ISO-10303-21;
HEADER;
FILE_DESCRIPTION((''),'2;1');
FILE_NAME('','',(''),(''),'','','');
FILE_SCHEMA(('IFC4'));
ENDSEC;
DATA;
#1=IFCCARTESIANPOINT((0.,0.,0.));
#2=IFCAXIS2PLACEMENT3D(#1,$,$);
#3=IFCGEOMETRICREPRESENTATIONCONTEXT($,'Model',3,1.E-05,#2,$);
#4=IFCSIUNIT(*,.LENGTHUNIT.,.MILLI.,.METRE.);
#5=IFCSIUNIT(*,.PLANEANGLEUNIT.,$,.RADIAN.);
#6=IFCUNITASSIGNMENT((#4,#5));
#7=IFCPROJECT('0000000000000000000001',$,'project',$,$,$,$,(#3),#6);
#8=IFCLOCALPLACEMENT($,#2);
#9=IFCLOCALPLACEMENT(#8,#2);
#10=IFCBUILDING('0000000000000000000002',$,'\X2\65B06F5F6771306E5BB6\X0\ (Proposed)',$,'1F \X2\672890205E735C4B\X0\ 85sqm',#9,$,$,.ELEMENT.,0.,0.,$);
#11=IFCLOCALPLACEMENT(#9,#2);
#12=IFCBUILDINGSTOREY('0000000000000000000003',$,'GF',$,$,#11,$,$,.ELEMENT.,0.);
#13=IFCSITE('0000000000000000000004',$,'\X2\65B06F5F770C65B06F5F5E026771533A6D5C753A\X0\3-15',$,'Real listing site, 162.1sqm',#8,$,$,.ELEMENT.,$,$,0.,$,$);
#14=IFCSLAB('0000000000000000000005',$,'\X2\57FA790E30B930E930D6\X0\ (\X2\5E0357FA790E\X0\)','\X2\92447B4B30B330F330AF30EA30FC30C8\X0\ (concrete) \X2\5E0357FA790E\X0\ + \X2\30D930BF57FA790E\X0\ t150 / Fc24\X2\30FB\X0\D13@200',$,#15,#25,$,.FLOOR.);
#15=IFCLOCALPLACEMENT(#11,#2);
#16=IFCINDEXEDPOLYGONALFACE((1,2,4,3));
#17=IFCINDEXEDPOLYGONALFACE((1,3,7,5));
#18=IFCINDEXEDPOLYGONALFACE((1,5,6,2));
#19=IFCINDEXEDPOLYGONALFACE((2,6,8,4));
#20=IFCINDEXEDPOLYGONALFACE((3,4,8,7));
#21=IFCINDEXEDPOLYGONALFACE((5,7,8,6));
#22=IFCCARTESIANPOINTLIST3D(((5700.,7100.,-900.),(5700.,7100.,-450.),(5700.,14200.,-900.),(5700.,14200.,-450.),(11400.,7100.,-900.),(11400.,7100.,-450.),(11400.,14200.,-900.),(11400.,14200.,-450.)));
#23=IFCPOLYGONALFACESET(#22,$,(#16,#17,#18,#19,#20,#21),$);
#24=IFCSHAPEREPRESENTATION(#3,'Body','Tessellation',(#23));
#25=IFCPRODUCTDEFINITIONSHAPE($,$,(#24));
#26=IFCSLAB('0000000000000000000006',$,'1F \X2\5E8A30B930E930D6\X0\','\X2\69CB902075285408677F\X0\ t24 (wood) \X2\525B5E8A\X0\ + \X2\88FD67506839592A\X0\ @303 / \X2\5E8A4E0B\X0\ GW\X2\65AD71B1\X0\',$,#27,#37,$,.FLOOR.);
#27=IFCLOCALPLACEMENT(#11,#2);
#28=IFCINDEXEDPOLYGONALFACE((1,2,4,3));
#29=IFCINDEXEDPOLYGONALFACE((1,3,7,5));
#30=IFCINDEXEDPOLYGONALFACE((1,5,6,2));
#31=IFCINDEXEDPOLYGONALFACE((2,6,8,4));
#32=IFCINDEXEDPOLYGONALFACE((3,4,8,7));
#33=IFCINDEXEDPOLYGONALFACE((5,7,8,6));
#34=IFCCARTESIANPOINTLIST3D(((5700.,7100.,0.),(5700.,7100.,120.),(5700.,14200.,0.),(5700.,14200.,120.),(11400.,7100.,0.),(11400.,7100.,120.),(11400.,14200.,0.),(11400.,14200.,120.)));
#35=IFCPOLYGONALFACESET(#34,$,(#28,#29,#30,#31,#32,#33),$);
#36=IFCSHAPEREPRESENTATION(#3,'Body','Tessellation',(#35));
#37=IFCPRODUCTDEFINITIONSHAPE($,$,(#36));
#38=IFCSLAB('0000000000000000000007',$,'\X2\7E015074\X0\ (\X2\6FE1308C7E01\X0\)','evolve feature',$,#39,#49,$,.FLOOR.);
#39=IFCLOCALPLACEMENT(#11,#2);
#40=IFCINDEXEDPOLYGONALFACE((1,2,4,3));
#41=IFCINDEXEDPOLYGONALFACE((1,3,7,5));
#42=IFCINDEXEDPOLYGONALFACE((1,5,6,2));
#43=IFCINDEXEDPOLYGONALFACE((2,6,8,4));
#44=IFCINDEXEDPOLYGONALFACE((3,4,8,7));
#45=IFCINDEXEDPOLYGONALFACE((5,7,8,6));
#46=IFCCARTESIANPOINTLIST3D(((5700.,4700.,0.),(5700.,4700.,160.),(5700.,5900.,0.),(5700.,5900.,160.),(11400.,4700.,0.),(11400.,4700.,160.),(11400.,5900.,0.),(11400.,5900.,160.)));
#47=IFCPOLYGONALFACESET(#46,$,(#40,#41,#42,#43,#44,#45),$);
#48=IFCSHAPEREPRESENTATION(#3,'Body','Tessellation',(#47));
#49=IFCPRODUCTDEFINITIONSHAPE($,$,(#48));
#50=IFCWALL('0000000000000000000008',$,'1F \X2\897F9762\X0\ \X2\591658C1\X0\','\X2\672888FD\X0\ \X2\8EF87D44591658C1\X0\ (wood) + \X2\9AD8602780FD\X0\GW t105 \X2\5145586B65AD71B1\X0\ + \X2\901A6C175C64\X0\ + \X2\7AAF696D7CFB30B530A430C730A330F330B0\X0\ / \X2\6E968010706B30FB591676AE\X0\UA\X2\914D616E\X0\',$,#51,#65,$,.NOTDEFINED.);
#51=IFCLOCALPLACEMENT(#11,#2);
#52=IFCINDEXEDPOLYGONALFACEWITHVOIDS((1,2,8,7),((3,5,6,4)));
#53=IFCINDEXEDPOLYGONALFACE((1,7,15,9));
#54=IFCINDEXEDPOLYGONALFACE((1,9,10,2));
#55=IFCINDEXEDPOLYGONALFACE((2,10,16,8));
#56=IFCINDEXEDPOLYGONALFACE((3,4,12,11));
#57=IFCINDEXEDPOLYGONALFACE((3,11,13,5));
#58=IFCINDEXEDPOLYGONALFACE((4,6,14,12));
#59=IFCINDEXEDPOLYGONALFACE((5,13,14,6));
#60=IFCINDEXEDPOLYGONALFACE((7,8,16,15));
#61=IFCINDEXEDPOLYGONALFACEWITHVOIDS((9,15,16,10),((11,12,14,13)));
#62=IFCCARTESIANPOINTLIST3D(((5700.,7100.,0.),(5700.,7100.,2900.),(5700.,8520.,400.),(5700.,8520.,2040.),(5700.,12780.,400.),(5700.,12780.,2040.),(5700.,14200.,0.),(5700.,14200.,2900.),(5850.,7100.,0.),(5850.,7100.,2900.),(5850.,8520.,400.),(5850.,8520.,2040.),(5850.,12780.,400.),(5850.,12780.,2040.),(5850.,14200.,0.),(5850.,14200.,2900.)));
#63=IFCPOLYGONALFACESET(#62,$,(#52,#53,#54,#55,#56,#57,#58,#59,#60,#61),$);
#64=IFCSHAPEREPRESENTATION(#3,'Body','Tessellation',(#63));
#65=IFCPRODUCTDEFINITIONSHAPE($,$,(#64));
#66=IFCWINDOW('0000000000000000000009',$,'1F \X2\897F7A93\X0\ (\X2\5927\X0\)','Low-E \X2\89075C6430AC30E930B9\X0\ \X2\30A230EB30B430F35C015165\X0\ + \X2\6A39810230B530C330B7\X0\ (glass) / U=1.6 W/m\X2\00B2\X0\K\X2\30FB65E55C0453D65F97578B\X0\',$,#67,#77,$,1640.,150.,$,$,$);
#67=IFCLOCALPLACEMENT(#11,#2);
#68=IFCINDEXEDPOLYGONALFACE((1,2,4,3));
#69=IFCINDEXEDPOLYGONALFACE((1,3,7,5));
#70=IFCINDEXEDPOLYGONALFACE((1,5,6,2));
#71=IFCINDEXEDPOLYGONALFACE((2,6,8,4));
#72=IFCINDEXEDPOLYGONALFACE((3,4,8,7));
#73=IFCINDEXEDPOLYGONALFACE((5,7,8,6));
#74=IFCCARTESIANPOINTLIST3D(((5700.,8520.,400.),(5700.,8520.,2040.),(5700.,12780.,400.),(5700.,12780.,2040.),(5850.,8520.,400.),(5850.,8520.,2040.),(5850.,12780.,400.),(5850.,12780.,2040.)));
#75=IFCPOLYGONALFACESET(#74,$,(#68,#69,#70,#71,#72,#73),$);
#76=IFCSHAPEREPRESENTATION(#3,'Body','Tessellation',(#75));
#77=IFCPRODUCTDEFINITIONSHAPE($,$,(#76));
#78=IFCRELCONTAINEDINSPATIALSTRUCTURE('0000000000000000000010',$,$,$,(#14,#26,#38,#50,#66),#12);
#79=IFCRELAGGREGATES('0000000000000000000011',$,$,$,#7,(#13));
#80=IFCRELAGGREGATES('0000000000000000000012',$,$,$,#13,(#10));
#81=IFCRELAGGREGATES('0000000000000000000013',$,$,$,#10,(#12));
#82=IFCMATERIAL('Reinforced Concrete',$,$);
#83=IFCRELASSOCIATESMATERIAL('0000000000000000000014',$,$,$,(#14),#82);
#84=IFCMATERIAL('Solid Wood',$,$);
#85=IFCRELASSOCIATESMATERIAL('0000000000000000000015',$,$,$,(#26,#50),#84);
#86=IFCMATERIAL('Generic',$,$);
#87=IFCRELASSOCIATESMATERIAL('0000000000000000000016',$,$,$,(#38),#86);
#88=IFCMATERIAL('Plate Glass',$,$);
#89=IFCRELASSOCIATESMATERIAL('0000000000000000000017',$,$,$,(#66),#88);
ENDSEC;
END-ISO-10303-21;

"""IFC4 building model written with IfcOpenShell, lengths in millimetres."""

from ifc_helpers import new_model, si_unit, frame, frame_2d, origin, place, context, project, spatial, rectangle, extrude, material, element, fill, save


model = new_model("IFC4")

# Units and contexts
model_context = context("Model", 3, precision=1e-05, world=origin())
ifc_project = project(units=[si_unit("LENGTHUNIT", "METRE", prefix="MILLI"), si_unit("PLANEANGLEUNIT", "RADIAN")], contexts=[model_context])

# Site, building, storey
site_placement = place(None, origin())
site = spatial("IfcSite", under=ifc_project, at=site_placement, Name="新潟県新潟市東区浜町3-15", ObjectType="Real listing site, 162.1sqm", CompositionType="ELEMENT", RefElevation=0.0)
building_placement = place(site_placement, origin())
building = spatial("IfcBuilding", under=site, at=building_placement, Name="新潟東の家 (Proposed)", ObjectType="1F 木造平屋 85sqm", CompositionType="ELEMENT", ElevationOfRefHeight=0.0, ElevationOfTerrain=0.0)
storey_placement = place(building_placement, origin())
storey = spatial("IfcBuildingStorey", under=building, at=storey_placement, Name="GF", CompositionType="ELEMENT", Elevation=0.0)

# Slabs
ifc_material_1 = material(Name="Reinforced Concrete")
slab_1_placement = place(storey_placement, frame((2850.0, 3550.0, -450.0)))
element("IfcSlab", 1, at=slab_1_placement, inside=storey, material=ifc_material_1, Name="基礎スラブ (布基礎)", Description="鉄筋コンクリート (concrete) 布基礎 + ベタ基礎 t150 / Fc24・D13@200", PredefinedType="FLOOR", context=model_context, shape_type="SweptSolid", body=[
    extrude(rectangle(XDim=5700.0, YDim=7100.0, at=frame_2d((2850.0, 3550.0))), frame((2850.0, 3550.0, -450.0)), (0.0, 0.0, 1.0), 450.0),
])
ifc_material_2 = material(Name="Solid Wood")
slab_2_placement = place(storey_placement, frame((2850.0, 3550.0, 0.0)))
element("IfcSlab", 2, at=slab_2_placement, inside=storey, material=ifc_material_2, Name="1F 床スラブ", Description="構造用合板 t24 (wood) 剛床 + 製材根太 @303 / 床下 GW断熱", PredefinedType="FLOOR", context=model_context, shape_type="SweptSolid", body=[
    extrude(rectangle(XDim=5700.0, YDim=7100.0, at=frame_2d((2850.0, 3550.0))), frame((2850.0, 3550.0, 0.0)), (0.0, 0.0, 1.0), 120.0),
])
ifc_material_3 = material(Name="Generic")
slab_3_placement = place(storey_placement, frame((2850.0, 2350.0, 0.0)))
element("IfcSlab", 3, at=slab_3_placement, inside=storey, material=ifc_material_3, Name="縁側 (濡れ縁)", Description="evolve feature", PredefinedType="FLOOR", context=model_context, shape_type="SweptSolid", body=[
    extrude(rectangle(XDim=5700.0, YDim=1200.0, at=frame_2d((2850.0, 600.0))), frame((2850.0, 2350.0, 0.0)), (0.0, 0.0, 1.0), 160.0),
])

# Shared definitions
ifc_material_4 = material(Name="Plate Glass")

# Wall, opening, window
wall_1_placement = place(storey_placement, frame((2850.0, 3550.0, 0.0)))
wall_1 = element("IfcWall", 4, at=wall_1_placement, inside=storey, material=ifc_material_2, Name="1F 西面 外壁", Description="木製 軸組外壁 (wood) + 高性能GW t105 充填断熱 + 通気層 + 窯業系サイディング / 準耐火・外皮UA配慮", PredefinedType="NOTDEFINED", context=model_context, shape_type="SweptSolid", body=[
    extrude(rectangle(XDim=150.0, YDim=7100.0, at=frame_2d((75.0, 3550.0))), frame((2850.0, 3550.0, 0.0)), (0.0, 0.0, 1.0), 2900.0),
])
opening_1_placement = place(storey_placement, frame((2850.0, 4260.0, 200.0)))
opening_1 = element("IfcOpeningElement", 5, at=opening_1_placement, cuts=wall_1, PredefinedType="NOTDEFINED", context=model_context, shape_type="SweptSolid", body=[
    extrude(rectangle(XDim=150.0, YDim=4260.0, at=frame_2d((75.0, 2130.0))), frame((2850.0, 4260.0, 200.0)), (0.0, 0.0, 1.0), 1640.0),
])
window_1_placement = place(storey_placement, frame((2850.0, 4260.0, 200.0)))
window_1 = element("IfcWindow", 6, at=window_1_placement, inside=storey, material=ifc_material_4, Name="1F 西窓 (大)", Description="Low-E 複層ガラス アルゴン封入 + 樹脂サッシ (glass) / U=1.6 W/m²K・日射取得型", OverallHeight=1640.0, OverallWidth=150.0, context=model_context, shape_type="SweptSolid", body=[
    extrude(rectangle(XDim=150.0, YDim=4260.0, at=frame_2d((75.0, 2130.0))), frame((2850.0, 4260.0, 200.0)), (0.0, 0.0, 1.0), 1640.0),
])
fill(opening_1, window_1)

save(model, "model.ifc")
